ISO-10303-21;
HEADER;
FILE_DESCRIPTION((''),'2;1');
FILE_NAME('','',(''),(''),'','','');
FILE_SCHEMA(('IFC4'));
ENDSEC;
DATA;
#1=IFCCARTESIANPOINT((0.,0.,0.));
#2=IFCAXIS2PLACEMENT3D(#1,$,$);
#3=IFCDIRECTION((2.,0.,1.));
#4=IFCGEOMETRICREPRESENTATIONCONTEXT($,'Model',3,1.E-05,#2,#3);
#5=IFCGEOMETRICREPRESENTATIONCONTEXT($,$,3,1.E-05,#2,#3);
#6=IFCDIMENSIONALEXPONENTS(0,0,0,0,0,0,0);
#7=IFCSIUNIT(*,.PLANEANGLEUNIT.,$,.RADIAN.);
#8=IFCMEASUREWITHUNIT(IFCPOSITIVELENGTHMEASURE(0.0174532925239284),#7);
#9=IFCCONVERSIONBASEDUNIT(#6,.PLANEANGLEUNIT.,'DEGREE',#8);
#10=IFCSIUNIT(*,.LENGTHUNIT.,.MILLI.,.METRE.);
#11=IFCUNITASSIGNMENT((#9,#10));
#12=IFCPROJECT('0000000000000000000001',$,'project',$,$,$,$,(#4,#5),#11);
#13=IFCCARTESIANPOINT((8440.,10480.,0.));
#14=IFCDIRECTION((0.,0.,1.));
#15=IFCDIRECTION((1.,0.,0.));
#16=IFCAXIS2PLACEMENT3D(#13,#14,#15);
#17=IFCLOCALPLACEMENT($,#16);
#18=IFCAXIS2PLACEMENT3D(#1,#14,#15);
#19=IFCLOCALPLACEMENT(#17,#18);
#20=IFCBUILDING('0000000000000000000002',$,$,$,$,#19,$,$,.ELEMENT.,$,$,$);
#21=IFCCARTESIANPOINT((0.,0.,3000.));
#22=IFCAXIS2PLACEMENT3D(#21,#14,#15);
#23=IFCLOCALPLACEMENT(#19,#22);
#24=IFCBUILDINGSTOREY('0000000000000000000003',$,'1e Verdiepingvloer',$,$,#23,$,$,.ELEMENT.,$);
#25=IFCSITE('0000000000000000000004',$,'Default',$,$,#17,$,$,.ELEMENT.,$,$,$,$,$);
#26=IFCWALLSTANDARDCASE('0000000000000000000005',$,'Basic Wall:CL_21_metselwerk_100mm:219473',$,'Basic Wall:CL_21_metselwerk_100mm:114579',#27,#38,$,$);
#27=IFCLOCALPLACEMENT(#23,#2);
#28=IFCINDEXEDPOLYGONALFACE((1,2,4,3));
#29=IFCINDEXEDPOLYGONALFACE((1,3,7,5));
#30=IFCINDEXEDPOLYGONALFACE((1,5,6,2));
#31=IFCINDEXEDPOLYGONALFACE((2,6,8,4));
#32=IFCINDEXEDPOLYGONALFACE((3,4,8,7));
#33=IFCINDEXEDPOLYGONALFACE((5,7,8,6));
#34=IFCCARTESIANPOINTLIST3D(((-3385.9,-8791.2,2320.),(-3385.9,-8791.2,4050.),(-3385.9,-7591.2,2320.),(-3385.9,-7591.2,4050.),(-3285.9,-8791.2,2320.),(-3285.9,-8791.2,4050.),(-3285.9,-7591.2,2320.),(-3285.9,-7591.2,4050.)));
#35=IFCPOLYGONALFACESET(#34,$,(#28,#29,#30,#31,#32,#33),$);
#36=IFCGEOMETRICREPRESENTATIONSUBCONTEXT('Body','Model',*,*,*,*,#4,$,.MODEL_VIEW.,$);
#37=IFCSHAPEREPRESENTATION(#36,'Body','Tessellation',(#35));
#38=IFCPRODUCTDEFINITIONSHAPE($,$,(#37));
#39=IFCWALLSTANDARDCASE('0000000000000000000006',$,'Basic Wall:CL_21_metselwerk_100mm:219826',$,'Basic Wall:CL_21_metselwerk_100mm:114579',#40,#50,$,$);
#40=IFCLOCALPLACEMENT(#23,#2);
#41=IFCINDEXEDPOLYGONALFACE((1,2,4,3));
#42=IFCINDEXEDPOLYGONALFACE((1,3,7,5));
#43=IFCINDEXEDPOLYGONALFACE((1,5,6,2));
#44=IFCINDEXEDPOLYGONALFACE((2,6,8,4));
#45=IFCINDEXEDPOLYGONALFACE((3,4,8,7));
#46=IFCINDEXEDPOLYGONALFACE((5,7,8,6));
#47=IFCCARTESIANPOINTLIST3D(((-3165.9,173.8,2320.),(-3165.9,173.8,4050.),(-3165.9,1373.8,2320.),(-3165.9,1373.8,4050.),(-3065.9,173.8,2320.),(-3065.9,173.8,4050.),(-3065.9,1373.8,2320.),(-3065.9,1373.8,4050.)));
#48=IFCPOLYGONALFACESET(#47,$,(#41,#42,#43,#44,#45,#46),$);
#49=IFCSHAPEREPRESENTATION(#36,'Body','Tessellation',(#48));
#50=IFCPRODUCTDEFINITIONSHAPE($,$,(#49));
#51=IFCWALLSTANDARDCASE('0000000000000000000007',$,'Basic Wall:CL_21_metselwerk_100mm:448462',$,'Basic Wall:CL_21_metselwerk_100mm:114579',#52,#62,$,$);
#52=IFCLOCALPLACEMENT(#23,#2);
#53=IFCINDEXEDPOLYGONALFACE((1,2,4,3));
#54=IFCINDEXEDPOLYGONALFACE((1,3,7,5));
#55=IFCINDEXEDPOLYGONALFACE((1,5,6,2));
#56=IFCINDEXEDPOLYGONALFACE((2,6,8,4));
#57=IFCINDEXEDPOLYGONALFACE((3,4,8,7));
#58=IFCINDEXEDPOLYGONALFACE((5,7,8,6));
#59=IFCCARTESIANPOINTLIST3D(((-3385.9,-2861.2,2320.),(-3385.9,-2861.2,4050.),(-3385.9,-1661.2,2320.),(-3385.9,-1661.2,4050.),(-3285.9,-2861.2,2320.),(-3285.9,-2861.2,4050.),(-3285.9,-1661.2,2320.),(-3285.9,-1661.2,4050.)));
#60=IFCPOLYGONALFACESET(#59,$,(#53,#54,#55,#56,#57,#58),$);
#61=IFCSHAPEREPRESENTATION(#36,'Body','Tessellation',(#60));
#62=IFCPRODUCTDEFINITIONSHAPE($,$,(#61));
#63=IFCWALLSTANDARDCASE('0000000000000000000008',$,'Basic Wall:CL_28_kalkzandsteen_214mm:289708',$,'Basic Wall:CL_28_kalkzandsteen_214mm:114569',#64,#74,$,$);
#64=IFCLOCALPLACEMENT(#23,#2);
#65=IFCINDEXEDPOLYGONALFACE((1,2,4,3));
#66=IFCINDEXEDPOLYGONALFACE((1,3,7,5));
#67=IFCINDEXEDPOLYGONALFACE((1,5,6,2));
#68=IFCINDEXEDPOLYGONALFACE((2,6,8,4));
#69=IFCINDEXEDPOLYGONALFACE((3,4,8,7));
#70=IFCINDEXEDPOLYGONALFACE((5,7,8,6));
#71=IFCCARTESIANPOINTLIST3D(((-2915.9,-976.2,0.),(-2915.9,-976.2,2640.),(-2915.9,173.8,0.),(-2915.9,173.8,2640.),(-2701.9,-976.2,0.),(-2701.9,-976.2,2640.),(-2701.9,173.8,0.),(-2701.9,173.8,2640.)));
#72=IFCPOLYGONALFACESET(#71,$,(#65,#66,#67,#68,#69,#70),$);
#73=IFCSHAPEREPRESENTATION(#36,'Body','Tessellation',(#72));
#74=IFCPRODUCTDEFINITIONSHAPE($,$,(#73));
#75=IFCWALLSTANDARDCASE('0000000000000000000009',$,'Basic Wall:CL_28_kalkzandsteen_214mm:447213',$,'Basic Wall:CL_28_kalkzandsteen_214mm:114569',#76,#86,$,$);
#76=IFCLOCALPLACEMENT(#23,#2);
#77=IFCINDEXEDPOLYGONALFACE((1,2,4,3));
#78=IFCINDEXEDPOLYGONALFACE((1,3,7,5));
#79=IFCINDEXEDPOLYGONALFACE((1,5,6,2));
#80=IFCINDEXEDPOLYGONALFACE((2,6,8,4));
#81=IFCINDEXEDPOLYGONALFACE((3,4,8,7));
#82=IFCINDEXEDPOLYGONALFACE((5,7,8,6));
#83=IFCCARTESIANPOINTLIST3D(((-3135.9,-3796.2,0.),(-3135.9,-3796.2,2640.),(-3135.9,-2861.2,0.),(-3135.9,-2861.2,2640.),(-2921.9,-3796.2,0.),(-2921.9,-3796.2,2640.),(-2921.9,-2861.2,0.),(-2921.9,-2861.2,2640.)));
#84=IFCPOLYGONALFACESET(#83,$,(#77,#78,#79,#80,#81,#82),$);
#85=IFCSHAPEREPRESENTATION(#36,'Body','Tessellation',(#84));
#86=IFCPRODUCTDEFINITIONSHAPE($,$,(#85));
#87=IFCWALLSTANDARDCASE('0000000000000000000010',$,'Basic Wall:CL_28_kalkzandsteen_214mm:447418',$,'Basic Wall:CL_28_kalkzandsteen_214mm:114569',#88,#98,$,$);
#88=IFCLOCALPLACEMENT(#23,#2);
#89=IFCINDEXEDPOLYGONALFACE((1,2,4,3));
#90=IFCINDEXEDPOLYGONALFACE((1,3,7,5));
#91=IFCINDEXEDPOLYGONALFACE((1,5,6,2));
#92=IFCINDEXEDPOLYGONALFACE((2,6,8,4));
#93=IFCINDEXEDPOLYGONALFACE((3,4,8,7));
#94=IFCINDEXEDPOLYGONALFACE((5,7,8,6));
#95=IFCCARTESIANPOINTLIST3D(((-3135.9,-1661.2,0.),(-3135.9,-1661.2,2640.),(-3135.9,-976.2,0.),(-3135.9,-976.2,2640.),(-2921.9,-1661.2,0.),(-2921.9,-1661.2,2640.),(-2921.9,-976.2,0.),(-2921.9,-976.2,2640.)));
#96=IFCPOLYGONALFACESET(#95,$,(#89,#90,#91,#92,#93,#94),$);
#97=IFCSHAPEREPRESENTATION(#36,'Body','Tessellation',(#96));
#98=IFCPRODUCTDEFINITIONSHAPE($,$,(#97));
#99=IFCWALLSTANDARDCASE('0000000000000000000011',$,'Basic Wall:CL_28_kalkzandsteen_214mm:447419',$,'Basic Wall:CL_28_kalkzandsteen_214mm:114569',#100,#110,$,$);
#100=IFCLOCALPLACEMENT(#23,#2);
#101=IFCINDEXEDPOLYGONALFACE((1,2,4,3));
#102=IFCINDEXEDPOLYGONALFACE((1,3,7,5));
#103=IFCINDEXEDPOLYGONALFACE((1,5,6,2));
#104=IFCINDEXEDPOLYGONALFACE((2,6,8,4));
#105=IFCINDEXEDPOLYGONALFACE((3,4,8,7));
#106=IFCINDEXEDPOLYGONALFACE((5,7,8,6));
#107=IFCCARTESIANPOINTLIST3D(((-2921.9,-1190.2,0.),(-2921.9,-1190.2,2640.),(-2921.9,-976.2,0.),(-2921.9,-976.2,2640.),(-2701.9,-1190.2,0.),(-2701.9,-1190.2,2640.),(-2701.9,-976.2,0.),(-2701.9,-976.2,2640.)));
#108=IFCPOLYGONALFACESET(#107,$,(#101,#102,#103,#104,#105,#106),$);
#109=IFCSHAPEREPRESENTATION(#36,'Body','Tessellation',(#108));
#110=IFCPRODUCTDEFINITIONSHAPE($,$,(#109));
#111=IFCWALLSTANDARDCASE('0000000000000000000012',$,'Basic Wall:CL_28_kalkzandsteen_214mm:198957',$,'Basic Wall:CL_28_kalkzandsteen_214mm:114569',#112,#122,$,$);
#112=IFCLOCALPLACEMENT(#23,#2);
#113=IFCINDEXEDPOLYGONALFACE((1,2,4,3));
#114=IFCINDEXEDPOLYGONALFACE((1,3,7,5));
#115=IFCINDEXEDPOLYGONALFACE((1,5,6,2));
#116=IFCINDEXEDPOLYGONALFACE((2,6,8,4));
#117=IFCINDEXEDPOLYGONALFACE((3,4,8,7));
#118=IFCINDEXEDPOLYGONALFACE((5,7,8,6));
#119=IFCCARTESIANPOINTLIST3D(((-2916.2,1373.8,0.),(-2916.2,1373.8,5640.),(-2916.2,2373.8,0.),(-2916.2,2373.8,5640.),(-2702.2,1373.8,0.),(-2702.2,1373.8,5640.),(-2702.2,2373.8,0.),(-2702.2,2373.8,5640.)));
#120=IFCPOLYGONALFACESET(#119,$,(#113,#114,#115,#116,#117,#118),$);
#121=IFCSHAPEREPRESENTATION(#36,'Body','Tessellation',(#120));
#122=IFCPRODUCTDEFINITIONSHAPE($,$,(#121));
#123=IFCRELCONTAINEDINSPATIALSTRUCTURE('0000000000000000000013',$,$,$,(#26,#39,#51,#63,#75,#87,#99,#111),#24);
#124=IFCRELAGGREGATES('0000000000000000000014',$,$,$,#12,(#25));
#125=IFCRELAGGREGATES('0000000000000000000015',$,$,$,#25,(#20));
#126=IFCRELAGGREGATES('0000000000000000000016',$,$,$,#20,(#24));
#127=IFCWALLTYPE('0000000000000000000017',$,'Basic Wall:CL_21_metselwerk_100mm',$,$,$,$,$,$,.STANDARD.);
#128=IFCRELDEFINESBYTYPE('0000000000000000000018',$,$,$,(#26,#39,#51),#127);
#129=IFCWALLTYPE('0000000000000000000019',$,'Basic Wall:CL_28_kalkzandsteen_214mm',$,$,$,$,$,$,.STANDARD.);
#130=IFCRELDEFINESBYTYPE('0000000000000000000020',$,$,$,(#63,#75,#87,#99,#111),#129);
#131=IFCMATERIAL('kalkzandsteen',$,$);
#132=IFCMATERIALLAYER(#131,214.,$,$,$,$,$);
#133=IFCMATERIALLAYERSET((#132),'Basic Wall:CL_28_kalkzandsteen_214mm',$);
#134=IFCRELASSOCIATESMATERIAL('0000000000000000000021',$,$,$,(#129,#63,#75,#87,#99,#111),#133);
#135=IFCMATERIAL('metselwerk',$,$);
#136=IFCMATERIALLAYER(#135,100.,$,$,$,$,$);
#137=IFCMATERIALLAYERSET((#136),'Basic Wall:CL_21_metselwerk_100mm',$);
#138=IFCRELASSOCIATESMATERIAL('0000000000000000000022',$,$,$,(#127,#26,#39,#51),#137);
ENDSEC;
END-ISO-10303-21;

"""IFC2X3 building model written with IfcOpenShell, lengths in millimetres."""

from ifc_helpers import new_model, entity, si_unit, converted_unit, direction, frame, frame_2d, origin, origin_with_axes, place, context, subcontext, project, spatial, rectangle, extrude, source, transform, mapped, material, layer, layer_set, layer_usage, type_object, element, save


model = new_model("IFC2X3")

# Units and contexts
model_context = context("Model", 3, precision=1e-05, world=origin(), true_north=direction((2.0, 0.0, 1.0)))
context_of_model = context(None, 3, precision=1e-05, world=origin(), true_north=direction((2.0, 0.0, 1.0)))
body_context = subcontext(model_context, "Body", "Model", "MODEL_VIEW")
ifc_project = project(units=[converted_unit("PLANEANGLEUNIT", "DEGREE", entity("IfcPositiveLengthMeasure", 0.0174532925239284), si_unit("PLANEANGLEUNIT", "RADIAN"), dimensions=[0, 0, 0, 0, 0, 0, 0]), si_unit("LENGTHUNIT", "METRE", prefix="MILLI")], contexts=[model_context, context_of_model])

# Site, building, storey
site_placement = place(None, frame((8440.0, 10480.0, 0.0), z_axis=(0.0, 0.0, 1.0), x_axis=(1.0, 0.0, 0.0)))
site = spatial("IfcSite", under=ifc_project, at=site_placement, Name="Default", CompositionType="ELEMENT")
building_placement = place(site_placement, origin_with_axes())
building = spatial("IfcBuilding", under=site, at=building_placement, CompositionType="ELEMENT")
storey_placement = place(building_placement, frame((0.0, 0.0, 3000.0), z_axis=(0.0, 0.0, 1.0), x_axis=(1.0, 0.0, 0.0)))
storey = spatial("IfcBuildingStorey", under=building, at=storey_placement, Name="1e Verdiepingvloer", CompositionType="ELEMENT")

# Walls
ifc_material_1 = material(Name="kalkzandsteen")
ifc_layer_1 = layer(ifc_material_1, 214.0)
ifc_layer_set_1 = layer_set([ifc_layer_1], Name="Basic Wall:CL_28_kalkzandsteen_214mm")
wall_type_1 = type_object("IfcWallType", Name="Basic Wall:CL_28_kalkzandsteen_214mm", PredefinedType="STANDARD", material=ifc_layer_set_1)
ifc_material_2 = material(Name="metselwerk")
ifc_layer_2 = layer(ifc_material_2, 100.0)
ifc_layer_set_2 = layer_set([ifc_layer_2], Name="Basic Wall:CL_21_metselwerk_100mm")
wall_type_2 = type_object("IfcWallType", Name="Basic Wall:CL_21_metselwerk_100mm", PredefinedType="STANDARD", material=ifc_layer_set_2)
shared_shape_1 = source(origin(), body_context, "Body", "SweptSolid", [
    extrude(rectangle(XDim=1200.0, YDim=100.0, at=frame_2d((600.0, 0.0), x_axis=(-1.0, 0.0))), origin(), (0.0, 0.0, 1.0), 1730.0),
])
ifc_layer_usage_1 = layer_usage(ifc_layer_set_2, "AXIS2", "NEGATIVE", 50.0)
wall_1_placement = place(storey_placement, frame((-3335.9, -7591.2, 2320.0), z_axis=(0.0, 0.0, 1.0), x_axis=(0.0, -1.0, 0.0)))
element("IfcWallStandardCase", 1, at=wall_1_placement, inside=storey, type_object=wall_type_2, material=ifc_layer_usage_1, Name="Basic Wall:CL_21_metselwerk_100mm:219473", ObjectType="Basic Wall:CL_21_metselwerk_100mm:114579", context=body_context, shape_type="MappedRepresentation", body=[
    mapped(shared_shape_1, transform((0.0, 0.0, 0.0))),
])
ifc_layer_usage_2 = layer_usage(ifc_layer_set_2, "AXIS2", "NEGATIVE", 50.0)
wall_2_placement = place(storey_placement, frame((-3115.9, 1373.8, 2320.0), z_axis=(0.0, 0.0, 1.0), x_axis=(0.0, -1.0, 0.0)))
element("IfcWallStandardCase", 2, at=wall_2_placement, inside=storey, type_object=wall_type_2, material=ifc_layer_usage_2, Name="Basic Wall:CL_21_metselwerk_100mm:219826", ObjectType="Basic Wall:CL_21_metselwerk_100mm:114579", context=body_context, shape_type="MappedRepresentation", body=[
    mapped(shared_shape_1, transform((0.0, 0.0, 0.0))),
])
ifc_layer_usage_3 = layer_usage(ifc_layer_set_2, "AXIS2", "NEGATIVE", 50.0)
wall_3_placement = place(storey_placement, frame((-3335.9, -1661.2, 2320.0), z_axis=(0.0, 0.0, 1.0), x_axis=(0.0, -1.0, 0.0)))
element("IfcWallStandardCase", 3, at=wall_3_placement, inside=storey, type_object=wall_type_2, material=ifc_layer_usage_3, Name="Basic Wall:CL_21_metselwerk_100mm:448462", ObjectType="Basic Wall:CL_21_metselwerk_100mm:114579", context=body_context, shape_type="MappedRepresentation", body=[
    mapped(shared_shape_1, transform((0.0, 0.0, 0.0))),
])
ifc_layer_usage_4 = layer_usage(ifc_layer_set_1, "AXIS2", "NEGATIVE", 107.0)
shared_shape_2 = source(origin(), body_context, "Body", "SweptSolid", [
    extrude(rectangle(XDim=1150.0, YDim=214.0, at=frame_2d((575.0, 0.0), x_axis=(-1.0, 0.0))), origin(), (0.0, 0.0, 1.0), 2640.0),
])
wall_4_placement = place(storey_placement, frame((-2808.9, 173.8, 0.0), z_axis=(0.0, 0.0, 1.0), x_axis=(0.0, -1.0, 0.0)))
element("IfcWallStandardCase", 4, at=wall_4_placement, inside=storey, type_object=wall_type_1, material=ifc_layer_usage_4, Name="Basic Wall:CL_28_kalkzandsteen_214mm:289708", ObjectType="Basic Wall:CL_28_kalkzandsteen_214mm:114569", context=body_context, shape_type="MappedRepresentation", body=[
    mapped(shared_shape_2, transform((0.0, 0.0, 0.0))),
])
ifc_layer_usage_5 = layer_usage(ifc_layer_set_1, "AXIS2", "NEGATIVE", 107.0)
shared_shape_3 = source(origin(), body_context, "Body", "SweptSolid", [
    extrude(rectangle(XDim=935.0, YDim=214.0, at=frame_2d((467.5, 0.0), x_axis=(-1.0, 0.0))), origin(), (0.0, 0.0, 1.0), 2640.0),
])
wall_5_placement = place(storey_placement, frame((-3028.9, -2861.2, 0.0), z_axis=(0.0, 0.0, 1.0), x_axis=(0.0, -1.0, 0.0)))
element("IfcWallStandardCase", 5, at=wall_5_placement, inside=storey, type_object=wall_type_1, material=ifc_layer_usage_5, Name="Basic Wall:CL_28_kalkzandsteen_214mm:447213", ObjectType="Basic Wall:CL_28_kalkzandsteen_214mm:114569", context=body_context, shape_type="MappedRepresentation", body=[
    mapped(shared_shape_3, transform((0.0, 0.0, 0.0))),
])
ifc_layer_usage_6 = layer_usage(ifc_layer_set_1, "AXIS2", "NEGATIVE", 107.0)
shared_shape_4 = source(origin(), body_context, "Body", "SweptSolid", [
    extrude(rectangle(XDim=685.0, YDim=214.0, at=frame_2d((342.5, 0.0), x_axis=(-1.0, 0.0))), origin(), (0.0, 0.0, 1.0), 2640.0),
])
wall_6_placement = place(storey_placement, frame((-3028.9, -976.2, 0.0), z_axis=(0.0, 0.0, 1.0), x_axis=(0.0, -1.0, 0.0)))
element("IfcWallStandardCase", 6, at=wall_6_placement, inside=storey, type_object=wall_type_1, material=ifc_layer_usage_6, Name="Basic Wall:CL_28_kalkzandsteen_214mm:447418", ObjectType="Basic Wall:CL_28_kalkzandsteen_214mm:114569", context=body_context, shape_type="MappedRepresentation", body=[
    mapped(shared_shape_4, transform((0.0, 0.0, 0.0))),
])
ifc_layer_usage_7 = layer_usage(ifc_layer_set_1, "AXIS2", "NEGATIVE", 107.0)
shared_shape_5 = source(origin(), body_context, "Body", "SweptSolid", [
    extrude(rectangle(XDim=220.0, YDim=214.0, at=frame_2d((110.0, 0.0), x_axis=(-1.0, 0.0))), origin(), (0.0, 0.0, 1.0), 2640.0),
])
wall_7_placement = place(storey_placement, frame((-2701.9, -1083.2, 0.0), z_axis=(0.0, 0.0, 1.0), x_axis=(-1.0, 0.0, 0.0)))
element("IfcWallStandardCase", 7, at=wall_7_placement, inside=storey, type_object=wall_type_1, material=ifc_layer_usage_7, Name="Basic Wall:CL_28_kalkzandsteen_214mm:447419", ObjectType="Basic Wall:CL_28_kalkzandsteen_214mm:114569", context=body_context, shape_type="MappedRepresentation", body=[
    mapped(shared_shape_5, transform((0.0, 0.0, 0.0))),
])
ifc_layer_usage_8 = layer_usage(ifc_layer_set_1, "AXIS2", "NEGATIVE", 107.0)
wall_8_placement = place(storey_placement, frame((-2809.2, 2373.8, 0.0), z_axis=(0.0, 0.0, 1.0), x_axis=(0.0, -1.0, 0.0)))
element("IfcWallStandardCase", 8, at=wall_8_placement, inside=storey, type_object=wall_type_1, material=ifc_layer_usage_8, Name="Basic Wall:CL_28_kalkzandsteen_214mm:198957", ObjectType="Basic Wall:CL_28_kalkzandsteen_214mm:114569", context=body_context, shape_type="SweptSolid", body=[
    extrude(rectangle(XDim=1000.0, YDim=214.0, at=frame_2d((500.0, 0.0), x_axis=(-1.0, 0.0))), origin(), (0.0, 0.0, 1.0), 5640.0),
])

save(model, "model.ifc")
